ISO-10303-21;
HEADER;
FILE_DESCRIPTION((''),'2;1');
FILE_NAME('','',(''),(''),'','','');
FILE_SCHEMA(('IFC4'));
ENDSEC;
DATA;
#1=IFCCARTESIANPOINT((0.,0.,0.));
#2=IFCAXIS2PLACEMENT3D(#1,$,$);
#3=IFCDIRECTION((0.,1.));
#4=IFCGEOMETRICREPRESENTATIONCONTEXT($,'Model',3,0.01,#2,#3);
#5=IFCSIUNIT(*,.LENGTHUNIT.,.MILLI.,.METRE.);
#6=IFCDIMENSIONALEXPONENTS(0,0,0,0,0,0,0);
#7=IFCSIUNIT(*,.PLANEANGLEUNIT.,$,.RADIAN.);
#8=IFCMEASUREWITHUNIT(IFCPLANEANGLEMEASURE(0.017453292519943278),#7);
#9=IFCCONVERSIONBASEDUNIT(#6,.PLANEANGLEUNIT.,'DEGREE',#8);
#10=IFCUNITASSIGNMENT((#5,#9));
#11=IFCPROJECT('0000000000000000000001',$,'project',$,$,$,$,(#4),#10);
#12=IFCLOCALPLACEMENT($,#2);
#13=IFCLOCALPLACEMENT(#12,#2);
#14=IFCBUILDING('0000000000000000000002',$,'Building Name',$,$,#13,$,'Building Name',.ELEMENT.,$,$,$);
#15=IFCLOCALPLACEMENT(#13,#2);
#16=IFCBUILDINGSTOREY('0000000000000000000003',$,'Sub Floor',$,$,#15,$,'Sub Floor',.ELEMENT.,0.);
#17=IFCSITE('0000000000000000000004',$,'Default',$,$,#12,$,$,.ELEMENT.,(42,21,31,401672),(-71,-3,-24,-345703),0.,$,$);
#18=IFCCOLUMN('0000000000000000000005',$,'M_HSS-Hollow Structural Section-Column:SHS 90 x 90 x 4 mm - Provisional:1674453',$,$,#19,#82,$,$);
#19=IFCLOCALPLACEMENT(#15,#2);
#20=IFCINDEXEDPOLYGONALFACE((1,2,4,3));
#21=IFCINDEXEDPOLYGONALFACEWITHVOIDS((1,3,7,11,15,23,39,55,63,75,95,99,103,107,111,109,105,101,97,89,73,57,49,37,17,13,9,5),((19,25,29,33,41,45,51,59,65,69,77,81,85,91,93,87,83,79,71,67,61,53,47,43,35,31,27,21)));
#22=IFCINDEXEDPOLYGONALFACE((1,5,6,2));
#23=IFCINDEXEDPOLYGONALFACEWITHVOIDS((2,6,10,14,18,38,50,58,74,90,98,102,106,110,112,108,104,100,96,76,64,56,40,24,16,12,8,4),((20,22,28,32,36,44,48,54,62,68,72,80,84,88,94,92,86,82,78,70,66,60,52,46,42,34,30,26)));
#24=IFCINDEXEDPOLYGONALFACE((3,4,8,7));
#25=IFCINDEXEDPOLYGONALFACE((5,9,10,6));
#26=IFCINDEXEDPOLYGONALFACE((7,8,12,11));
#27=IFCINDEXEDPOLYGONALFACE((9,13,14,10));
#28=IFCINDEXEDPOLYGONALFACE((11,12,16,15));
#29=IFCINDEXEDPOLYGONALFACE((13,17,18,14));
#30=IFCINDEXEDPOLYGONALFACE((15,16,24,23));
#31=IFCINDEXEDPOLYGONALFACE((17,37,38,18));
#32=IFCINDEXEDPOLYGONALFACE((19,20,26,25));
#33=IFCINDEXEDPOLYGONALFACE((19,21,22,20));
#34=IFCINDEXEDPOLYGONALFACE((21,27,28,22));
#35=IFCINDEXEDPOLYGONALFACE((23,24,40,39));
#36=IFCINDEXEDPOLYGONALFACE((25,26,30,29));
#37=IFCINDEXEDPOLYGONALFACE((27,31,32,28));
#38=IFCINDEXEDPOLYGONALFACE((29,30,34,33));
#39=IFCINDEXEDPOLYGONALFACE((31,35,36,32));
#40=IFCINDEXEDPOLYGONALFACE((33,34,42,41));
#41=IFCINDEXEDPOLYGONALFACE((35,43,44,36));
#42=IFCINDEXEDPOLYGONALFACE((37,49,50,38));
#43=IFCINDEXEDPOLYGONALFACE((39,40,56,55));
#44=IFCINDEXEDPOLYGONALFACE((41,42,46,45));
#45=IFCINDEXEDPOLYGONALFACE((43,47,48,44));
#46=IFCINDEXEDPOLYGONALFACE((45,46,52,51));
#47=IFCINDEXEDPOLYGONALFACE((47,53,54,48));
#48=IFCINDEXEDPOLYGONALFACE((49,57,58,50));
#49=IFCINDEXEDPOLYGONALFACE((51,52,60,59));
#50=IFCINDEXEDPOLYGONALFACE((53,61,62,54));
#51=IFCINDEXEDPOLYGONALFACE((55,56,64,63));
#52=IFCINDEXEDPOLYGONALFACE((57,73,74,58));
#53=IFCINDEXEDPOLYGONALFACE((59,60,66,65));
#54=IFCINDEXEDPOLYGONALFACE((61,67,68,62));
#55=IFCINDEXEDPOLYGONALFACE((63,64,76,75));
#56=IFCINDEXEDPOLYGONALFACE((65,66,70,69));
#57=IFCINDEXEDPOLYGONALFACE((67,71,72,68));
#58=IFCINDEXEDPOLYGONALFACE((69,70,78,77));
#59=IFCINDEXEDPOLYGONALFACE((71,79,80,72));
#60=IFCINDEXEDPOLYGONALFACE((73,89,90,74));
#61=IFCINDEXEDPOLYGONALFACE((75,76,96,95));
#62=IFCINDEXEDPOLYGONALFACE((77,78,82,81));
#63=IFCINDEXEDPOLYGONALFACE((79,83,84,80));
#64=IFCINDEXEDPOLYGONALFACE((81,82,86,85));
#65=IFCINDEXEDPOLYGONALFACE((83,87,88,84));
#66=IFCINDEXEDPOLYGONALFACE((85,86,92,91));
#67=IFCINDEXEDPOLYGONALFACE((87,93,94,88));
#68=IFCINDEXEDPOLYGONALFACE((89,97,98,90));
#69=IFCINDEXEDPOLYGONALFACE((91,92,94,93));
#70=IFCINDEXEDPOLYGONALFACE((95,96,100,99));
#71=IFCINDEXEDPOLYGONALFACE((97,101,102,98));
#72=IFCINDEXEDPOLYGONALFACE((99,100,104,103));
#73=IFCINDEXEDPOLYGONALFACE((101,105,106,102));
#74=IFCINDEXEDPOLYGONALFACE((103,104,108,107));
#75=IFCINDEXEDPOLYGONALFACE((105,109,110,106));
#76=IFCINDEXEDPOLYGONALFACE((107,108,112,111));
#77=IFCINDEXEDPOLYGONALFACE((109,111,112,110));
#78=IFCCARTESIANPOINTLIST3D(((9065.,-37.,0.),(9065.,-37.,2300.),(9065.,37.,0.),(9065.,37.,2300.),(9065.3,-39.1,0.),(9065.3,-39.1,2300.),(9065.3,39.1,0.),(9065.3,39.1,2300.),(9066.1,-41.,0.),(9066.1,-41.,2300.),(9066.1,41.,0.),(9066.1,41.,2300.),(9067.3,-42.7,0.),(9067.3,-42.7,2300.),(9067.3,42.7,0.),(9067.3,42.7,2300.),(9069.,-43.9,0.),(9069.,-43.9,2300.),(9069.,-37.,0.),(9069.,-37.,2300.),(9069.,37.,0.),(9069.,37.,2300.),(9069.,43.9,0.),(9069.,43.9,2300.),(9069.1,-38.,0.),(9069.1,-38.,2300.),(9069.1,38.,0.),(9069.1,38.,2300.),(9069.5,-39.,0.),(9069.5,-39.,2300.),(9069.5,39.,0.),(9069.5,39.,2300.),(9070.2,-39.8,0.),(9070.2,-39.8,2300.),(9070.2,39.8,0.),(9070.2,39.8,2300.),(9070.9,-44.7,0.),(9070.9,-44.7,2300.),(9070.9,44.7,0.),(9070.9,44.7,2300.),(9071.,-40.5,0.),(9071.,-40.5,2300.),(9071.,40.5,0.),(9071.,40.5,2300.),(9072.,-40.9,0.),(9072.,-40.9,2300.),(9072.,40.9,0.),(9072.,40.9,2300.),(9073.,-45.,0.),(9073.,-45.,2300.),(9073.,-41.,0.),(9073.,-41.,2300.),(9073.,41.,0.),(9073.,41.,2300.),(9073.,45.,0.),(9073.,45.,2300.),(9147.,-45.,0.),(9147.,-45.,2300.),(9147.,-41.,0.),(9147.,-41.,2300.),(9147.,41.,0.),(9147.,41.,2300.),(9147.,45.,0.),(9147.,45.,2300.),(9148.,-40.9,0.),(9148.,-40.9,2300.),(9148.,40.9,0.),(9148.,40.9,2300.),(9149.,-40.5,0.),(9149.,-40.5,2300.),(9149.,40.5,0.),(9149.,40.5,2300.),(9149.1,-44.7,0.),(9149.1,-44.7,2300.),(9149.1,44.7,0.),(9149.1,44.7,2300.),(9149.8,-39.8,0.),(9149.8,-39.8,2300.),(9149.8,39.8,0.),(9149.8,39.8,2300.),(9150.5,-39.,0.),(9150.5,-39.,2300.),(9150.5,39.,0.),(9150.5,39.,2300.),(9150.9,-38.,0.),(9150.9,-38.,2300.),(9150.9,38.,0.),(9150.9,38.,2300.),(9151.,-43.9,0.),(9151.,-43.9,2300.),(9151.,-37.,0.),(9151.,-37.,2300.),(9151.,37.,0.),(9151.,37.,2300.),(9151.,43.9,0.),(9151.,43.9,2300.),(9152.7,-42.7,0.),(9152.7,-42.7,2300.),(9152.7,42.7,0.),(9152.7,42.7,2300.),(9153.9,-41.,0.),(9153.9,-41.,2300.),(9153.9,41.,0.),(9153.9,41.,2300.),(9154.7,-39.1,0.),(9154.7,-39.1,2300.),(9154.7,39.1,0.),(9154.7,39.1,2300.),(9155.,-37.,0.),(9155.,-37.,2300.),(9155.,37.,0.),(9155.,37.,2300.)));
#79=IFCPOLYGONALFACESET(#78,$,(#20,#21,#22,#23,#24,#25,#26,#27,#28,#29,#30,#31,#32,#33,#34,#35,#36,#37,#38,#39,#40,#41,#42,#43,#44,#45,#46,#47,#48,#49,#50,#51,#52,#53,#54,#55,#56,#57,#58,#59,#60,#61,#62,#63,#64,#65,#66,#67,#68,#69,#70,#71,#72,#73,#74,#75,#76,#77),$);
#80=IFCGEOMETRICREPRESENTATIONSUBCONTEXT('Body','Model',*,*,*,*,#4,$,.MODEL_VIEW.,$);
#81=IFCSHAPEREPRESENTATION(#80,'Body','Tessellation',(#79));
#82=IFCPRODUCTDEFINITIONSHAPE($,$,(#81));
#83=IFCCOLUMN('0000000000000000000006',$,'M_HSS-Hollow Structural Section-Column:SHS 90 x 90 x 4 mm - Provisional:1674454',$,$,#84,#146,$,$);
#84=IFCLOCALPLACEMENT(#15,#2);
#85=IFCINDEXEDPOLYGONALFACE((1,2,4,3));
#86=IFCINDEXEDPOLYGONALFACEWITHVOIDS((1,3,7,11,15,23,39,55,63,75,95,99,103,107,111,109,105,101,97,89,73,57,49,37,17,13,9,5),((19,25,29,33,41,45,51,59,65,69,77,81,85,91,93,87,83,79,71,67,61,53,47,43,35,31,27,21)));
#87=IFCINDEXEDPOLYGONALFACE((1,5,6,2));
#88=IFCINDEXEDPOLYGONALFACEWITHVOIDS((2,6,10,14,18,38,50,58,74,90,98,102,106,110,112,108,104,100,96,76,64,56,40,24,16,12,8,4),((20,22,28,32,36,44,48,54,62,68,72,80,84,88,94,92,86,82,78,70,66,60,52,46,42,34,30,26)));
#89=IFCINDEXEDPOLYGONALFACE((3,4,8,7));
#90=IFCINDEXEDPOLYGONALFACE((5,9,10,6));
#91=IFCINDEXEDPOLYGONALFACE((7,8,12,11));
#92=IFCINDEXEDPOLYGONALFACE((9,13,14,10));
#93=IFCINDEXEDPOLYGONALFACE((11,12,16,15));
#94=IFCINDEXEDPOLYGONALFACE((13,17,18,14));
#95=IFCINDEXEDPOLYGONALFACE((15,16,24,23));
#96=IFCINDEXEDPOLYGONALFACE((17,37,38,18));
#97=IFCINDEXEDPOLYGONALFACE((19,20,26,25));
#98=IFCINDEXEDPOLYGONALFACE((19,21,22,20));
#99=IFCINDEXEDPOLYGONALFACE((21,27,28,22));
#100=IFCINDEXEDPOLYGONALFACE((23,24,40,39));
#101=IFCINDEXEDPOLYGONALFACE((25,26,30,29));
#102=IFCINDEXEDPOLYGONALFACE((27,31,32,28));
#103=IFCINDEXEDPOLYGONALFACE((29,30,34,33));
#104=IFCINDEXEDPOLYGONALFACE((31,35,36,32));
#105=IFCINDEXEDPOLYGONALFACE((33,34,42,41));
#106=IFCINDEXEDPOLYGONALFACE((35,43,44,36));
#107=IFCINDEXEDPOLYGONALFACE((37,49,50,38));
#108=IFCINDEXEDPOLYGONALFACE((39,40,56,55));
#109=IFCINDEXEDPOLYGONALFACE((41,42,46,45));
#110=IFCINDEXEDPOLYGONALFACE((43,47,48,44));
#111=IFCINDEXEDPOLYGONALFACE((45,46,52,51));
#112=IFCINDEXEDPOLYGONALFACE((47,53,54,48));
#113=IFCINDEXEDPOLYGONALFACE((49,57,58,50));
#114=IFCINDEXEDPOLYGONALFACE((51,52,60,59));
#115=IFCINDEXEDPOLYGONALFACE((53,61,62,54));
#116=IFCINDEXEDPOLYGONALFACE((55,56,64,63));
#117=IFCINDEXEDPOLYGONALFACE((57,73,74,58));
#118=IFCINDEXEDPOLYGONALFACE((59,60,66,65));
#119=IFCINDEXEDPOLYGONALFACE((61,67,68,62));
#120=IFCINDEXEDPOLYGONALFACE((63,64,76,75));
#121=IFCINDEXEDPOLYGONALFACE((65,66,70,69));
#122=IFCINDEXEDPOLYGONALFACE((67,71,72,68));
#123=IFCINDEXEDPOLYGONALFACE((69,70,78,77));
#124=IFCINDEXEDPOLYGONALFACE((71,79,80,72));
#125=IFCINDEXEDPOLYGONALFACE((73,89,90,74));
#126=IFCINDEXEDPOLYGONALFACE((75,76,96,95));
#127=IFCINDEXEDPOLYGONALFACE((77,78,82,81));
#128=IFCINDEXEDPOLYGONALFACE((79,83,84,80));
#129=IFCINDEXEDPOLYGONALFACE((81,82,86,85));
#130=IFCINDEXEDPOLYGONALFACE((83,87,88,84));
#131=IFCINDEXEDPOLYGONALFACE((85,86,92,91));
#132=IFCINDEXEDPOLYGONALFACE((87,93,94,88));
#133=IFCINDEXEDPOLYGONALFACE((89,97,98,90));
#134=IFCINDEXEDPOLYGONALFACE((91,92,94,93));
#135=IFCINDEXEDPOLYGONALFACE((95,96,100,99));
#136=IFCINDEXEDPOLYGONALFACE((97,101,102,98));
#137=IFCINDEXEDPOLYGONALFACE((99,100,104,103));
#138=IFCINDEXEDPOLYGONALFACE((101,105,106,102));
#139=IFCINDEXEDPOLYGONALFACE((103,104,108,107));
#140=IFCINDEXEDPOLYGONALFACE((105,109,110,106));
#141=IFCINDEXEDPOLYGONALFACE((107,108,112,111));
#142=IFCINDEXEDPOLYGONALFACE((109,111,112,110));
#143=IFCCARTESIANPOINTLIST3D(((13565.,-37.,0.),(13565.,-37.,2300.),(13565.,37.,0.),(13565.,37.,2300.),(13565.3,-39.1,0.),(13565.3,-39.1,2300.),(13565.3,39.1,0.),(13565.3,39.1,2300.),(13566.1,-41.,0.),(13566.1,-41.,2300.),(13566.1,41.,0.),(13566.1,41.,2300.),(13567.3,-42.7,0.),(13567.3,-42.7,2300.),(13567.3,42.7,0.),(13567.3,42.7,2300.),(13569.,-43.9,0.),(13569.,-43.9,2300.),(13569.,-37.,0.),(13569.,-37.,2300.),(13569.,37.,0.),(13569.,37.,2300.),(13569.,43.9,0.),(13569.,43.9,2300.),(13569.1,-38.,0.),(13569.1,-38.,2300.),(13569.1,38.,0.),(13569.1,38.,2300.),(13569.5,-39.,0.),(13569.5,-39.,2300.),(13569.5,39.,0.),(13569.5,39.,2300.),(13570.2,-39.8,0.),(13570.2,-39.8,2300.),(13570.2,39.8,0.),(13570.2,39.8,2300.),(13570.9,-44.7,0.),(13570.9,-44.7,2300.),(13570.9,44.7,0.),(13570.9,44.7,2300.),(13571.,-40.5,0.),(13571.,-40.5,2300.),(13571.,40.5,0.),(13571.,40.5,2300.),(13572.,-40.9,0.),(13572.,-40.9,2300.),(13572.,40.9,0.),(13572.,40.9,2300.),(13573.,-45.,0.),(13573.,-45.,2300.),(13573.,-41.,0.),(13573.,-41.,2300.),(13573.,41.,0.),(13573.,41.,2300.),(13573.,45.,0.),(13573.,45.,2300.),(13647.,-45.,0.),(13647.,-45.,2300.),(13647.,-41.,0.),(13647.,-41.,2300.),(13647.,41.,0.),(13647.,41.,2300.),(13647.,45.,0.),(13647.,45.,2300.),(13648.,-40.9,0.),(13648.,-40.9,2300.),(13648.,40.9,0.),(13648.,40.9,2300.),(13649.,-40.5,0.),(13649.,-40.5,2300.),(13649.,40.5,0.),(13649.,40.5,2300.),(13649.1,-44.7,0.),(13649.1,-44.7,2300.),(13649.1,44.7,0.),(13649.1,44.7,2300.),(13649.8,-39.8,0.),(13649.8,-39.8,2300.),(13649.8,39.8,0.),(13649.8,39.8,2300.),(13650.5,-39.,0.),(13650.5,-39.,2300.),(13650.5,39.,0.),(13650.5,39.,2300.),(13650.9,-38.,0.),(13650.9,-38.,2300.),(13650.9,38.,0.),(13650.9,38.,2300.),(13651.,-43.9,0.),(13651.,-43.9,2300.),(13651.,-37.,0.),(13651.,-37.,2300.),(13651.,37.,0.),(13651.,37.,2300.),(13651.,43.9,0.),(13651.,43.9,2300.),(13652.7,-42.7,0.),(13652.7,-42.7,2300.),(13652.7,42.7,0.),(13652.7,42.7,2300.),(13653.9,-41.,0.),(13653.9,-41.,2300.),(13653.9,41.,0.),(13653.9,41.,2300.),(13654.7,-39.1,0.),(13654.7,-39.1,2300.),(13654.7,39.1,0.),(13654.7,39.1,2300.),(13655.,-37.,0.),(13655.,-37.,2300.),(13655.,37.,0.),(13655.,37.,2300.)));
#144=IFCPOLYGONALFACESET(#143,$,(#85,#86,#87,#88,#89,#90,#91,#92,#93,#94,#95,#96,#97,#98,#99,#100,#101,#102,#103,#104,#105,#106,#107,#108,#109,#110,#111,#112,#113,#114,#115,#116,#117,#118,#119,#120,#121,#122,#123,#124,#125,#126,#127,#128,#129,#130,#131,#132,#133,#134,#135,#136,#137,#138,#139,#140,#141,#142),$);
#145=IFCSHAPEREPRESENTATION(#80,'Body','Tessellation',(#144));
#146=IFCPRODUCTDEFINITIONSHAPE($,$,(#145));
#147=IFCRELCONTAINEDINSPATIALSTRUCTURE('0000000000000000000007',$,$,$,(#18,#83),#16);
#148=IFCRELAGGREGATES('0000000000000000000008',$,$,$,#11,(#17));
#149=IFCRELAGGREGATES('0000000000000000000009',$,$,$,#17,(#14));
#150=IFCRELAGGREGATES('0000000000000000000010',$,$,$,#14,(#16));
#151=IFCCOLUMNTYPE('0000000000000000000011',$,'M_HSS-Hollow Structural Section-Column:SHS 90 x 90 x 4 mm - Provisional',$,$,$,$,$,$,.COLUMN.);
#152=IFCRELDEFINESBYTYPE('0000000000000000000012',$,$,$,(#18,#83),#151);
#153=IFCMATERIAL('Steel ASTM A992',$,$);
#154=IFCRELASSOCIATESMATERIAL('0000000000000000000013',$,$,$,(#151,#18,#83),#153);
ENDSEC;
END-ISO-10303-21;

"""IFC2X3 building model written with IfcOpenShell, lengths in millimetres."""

from ifc_helpers import new_model, entity, si_unit, converted_unit, direction, frame, frame_2d, origin, place, context, subcontext, project, spatial, polyline, circle_curve, parameter, trimmed, segment, composite_curve, outline, extrude, source, transform, mapped, material, type_object, type_shapes, element, save


model = new_model("IFC2X3")

# Units and contexts
model_context = context("Model", 3, precision=0.01, world=origin(), true_north=direction((0.0, 1.0)))
body_context = subcontext(model_context, "Body", "Model", "MODEL_VIEW")
ifc_project = project(units=[si_unit("LENGTHUNIT", "METRE", prefix="MILLI"), converted_unit("PLANEANGLEUNIT", "DEGREE", entity("IfcPlaneAngleMeasure", 0.017453292519943278), si_unit("PLANEANGLEUNIT", "RADIAN"), dimensions=[0, 0, 0, 0, 0, 0, 0])], contexts=[model_context])

# Site, building, storey
site_placement = place(None, origin())
site = spatial("IfcSite", under=ifc_project, at=site_placement, Name="Default", CompositionType="ELEMENT", RefLatitude=(42, 21, 31, 401672), RefLongitude=(-71, -3, -24, -345703), RefElevation=0.0)
building_placement = place(site_placement, origin())
building = spatial("IfcBuilding", under=site, at=building_placement, Name="Building Name", LongName="Building Name", CompositionType="ELEMENT")
storey_placement = place(building_placement, origin())
storey = spatial("IfcBuildingStorey", under=building, at=storey_placement, Name="Sub Floor", LongName="Sub Floor", CompositionType="ELEMENT", Elevation=0.0)

# Columns
ifc_material_1 = material(Name="Steel ASTM A992")
column_type = type_object("IfcColumnType", Name="M_HSS-Hollow Structural Section-Column:SHS 90 x 90 x 4 mm - Provisional", PredefinedType="COLUMN", material=ifc_material_1)
shared_shape_1 = source(origin(), body_context, "Body", "SweptSolid", [
    extrude(outline(composite_curve([segment(polyline([(-37.0, -45.0), (37.0, -45.0)]), True, "CONTINUOUS"), segment(trimmed(circle_curve(frame_2d((37.0, -37.0), x_axis=(-1.0, 0.0)), 8.0), [parameter(90.0)], [parameter(180.0)], True, "PARAMETER"), True, "CONTINUOUS"), segment(polyline([(45.0, -37.0), (45.0, 37.0)]), True, "CONTINUOUS"), segment(trimmed(circle_curve(frame_2d((37.0, 37.0), x_axis=(-1.0, 0.0)), 8.0), [parameter(180.0)], [parameter(270.0)], True, "PARAMETER"), True, "CONTINUOUS"), segment(polyline([(37.0, 45.0), (-37.0, 45.0)]), True, "CONTINUOUS"), segment(trimmed(circle_curve(frame_2d((-37.0, 37.0), x_axis=(-1.0, 0.0)), 8.0), [parameter(270.0)], [parameter(360.0)], True, "PARAMETER"), True, "CONTINUOUS"), segment(polyline([(-45.0, 37.0), (-45.0, -37.0)]), True, "CONTINUOUS"), segment(trimmed(circle_curve(frame_2d((-37.0, -37.0), x_axis=(-1.0, 0.0)), 8.0), [parameter(360.0)], [parameter(90.0)], True, "PARAMETER"), True, "CONTINUOUS")], self_intersect=False), holes=[composite_curve([segment(trimmed(circle_curve(frame_2d((-37.0, -37.0), x_axis=(-1.0, 0.0)), 4.0), [parameter(0.0)], [parameter(90.0)], True, "PARAMETER"), False, "CONTINUOUS"), segment(polyline([(-41.0, -37.0), (-41.0, 37.0)]), True, "CONTINUOUS"), segment(trimmed(circle_curve(frame_2d((-37.0, 37.0), x_axis=(-1.0, 0.0)), 4.0), [parameter(270.0)], [parameter(0.0)], True, "PARAMETER"), False, "CONTINUOUS"), segment(polyline([(-37.0, 41.0), (37.0, 41.0)]), True, "CONTINUOUS"), segment(trimmed(circle_curve(frame_2d((37.0, 37.0), x_axis=(-1.0, 0.0)), 4.0), [parameter(180.0)], [parameter(270.0)], True, "PARAMETER"), False, "CONTINUOUS"), segment(polyline([(41.0, 37.0), (41.0, -37.0)]), True, "CONTINUOUS"), segment(trimmed(circle_curve(frame_2d((37.0, -37.0), x_axis=(-1.0, 0.0)), 4.0), [parameter(90.0)], [parameter(180.0)], True, "PARAMETER"), False, "CONTINUOUS"), segment(polyline([(37.0, -41.0), (-37.0, -41.0)]), True, "CONTINUOUS")], self_intersect=False)]), frame((0.0, 0.0, 0.0), z_axis=(0.0, 0.0, 1.0), x_axis=(-1.0, 0.0, 0.0)), (0.0, 0.0, 1.0), 2300.0),
])
type_shapes(column_type, [shared_shape_1])
for number, where, name in (
    (1, (9110.0, 0.0, 0.0), "M_HSS-Hollow Structural Section-Column:SHS 90 x 90 x 4 mm - Provisional:1674453"),
    (2, (13610.0, 0.0, 0.0), "M_HSS-Hollow Structural Section-Column:SHS 90 x 90 x 4 mm - Provisional:1674454"),
):
    element("IfcColumn", number, at=place(storey_placement, frame(where)), inside=storey, type_object=column_type, material=ifc_material_1, Name=name, context=body_context, shape_type="MappedRepresentation", body=[
        mapped(shared_shape_1, transform((0.0, 0.0, 0.0), scale=1.0)),
    ])

save(model, "model.ifc")
